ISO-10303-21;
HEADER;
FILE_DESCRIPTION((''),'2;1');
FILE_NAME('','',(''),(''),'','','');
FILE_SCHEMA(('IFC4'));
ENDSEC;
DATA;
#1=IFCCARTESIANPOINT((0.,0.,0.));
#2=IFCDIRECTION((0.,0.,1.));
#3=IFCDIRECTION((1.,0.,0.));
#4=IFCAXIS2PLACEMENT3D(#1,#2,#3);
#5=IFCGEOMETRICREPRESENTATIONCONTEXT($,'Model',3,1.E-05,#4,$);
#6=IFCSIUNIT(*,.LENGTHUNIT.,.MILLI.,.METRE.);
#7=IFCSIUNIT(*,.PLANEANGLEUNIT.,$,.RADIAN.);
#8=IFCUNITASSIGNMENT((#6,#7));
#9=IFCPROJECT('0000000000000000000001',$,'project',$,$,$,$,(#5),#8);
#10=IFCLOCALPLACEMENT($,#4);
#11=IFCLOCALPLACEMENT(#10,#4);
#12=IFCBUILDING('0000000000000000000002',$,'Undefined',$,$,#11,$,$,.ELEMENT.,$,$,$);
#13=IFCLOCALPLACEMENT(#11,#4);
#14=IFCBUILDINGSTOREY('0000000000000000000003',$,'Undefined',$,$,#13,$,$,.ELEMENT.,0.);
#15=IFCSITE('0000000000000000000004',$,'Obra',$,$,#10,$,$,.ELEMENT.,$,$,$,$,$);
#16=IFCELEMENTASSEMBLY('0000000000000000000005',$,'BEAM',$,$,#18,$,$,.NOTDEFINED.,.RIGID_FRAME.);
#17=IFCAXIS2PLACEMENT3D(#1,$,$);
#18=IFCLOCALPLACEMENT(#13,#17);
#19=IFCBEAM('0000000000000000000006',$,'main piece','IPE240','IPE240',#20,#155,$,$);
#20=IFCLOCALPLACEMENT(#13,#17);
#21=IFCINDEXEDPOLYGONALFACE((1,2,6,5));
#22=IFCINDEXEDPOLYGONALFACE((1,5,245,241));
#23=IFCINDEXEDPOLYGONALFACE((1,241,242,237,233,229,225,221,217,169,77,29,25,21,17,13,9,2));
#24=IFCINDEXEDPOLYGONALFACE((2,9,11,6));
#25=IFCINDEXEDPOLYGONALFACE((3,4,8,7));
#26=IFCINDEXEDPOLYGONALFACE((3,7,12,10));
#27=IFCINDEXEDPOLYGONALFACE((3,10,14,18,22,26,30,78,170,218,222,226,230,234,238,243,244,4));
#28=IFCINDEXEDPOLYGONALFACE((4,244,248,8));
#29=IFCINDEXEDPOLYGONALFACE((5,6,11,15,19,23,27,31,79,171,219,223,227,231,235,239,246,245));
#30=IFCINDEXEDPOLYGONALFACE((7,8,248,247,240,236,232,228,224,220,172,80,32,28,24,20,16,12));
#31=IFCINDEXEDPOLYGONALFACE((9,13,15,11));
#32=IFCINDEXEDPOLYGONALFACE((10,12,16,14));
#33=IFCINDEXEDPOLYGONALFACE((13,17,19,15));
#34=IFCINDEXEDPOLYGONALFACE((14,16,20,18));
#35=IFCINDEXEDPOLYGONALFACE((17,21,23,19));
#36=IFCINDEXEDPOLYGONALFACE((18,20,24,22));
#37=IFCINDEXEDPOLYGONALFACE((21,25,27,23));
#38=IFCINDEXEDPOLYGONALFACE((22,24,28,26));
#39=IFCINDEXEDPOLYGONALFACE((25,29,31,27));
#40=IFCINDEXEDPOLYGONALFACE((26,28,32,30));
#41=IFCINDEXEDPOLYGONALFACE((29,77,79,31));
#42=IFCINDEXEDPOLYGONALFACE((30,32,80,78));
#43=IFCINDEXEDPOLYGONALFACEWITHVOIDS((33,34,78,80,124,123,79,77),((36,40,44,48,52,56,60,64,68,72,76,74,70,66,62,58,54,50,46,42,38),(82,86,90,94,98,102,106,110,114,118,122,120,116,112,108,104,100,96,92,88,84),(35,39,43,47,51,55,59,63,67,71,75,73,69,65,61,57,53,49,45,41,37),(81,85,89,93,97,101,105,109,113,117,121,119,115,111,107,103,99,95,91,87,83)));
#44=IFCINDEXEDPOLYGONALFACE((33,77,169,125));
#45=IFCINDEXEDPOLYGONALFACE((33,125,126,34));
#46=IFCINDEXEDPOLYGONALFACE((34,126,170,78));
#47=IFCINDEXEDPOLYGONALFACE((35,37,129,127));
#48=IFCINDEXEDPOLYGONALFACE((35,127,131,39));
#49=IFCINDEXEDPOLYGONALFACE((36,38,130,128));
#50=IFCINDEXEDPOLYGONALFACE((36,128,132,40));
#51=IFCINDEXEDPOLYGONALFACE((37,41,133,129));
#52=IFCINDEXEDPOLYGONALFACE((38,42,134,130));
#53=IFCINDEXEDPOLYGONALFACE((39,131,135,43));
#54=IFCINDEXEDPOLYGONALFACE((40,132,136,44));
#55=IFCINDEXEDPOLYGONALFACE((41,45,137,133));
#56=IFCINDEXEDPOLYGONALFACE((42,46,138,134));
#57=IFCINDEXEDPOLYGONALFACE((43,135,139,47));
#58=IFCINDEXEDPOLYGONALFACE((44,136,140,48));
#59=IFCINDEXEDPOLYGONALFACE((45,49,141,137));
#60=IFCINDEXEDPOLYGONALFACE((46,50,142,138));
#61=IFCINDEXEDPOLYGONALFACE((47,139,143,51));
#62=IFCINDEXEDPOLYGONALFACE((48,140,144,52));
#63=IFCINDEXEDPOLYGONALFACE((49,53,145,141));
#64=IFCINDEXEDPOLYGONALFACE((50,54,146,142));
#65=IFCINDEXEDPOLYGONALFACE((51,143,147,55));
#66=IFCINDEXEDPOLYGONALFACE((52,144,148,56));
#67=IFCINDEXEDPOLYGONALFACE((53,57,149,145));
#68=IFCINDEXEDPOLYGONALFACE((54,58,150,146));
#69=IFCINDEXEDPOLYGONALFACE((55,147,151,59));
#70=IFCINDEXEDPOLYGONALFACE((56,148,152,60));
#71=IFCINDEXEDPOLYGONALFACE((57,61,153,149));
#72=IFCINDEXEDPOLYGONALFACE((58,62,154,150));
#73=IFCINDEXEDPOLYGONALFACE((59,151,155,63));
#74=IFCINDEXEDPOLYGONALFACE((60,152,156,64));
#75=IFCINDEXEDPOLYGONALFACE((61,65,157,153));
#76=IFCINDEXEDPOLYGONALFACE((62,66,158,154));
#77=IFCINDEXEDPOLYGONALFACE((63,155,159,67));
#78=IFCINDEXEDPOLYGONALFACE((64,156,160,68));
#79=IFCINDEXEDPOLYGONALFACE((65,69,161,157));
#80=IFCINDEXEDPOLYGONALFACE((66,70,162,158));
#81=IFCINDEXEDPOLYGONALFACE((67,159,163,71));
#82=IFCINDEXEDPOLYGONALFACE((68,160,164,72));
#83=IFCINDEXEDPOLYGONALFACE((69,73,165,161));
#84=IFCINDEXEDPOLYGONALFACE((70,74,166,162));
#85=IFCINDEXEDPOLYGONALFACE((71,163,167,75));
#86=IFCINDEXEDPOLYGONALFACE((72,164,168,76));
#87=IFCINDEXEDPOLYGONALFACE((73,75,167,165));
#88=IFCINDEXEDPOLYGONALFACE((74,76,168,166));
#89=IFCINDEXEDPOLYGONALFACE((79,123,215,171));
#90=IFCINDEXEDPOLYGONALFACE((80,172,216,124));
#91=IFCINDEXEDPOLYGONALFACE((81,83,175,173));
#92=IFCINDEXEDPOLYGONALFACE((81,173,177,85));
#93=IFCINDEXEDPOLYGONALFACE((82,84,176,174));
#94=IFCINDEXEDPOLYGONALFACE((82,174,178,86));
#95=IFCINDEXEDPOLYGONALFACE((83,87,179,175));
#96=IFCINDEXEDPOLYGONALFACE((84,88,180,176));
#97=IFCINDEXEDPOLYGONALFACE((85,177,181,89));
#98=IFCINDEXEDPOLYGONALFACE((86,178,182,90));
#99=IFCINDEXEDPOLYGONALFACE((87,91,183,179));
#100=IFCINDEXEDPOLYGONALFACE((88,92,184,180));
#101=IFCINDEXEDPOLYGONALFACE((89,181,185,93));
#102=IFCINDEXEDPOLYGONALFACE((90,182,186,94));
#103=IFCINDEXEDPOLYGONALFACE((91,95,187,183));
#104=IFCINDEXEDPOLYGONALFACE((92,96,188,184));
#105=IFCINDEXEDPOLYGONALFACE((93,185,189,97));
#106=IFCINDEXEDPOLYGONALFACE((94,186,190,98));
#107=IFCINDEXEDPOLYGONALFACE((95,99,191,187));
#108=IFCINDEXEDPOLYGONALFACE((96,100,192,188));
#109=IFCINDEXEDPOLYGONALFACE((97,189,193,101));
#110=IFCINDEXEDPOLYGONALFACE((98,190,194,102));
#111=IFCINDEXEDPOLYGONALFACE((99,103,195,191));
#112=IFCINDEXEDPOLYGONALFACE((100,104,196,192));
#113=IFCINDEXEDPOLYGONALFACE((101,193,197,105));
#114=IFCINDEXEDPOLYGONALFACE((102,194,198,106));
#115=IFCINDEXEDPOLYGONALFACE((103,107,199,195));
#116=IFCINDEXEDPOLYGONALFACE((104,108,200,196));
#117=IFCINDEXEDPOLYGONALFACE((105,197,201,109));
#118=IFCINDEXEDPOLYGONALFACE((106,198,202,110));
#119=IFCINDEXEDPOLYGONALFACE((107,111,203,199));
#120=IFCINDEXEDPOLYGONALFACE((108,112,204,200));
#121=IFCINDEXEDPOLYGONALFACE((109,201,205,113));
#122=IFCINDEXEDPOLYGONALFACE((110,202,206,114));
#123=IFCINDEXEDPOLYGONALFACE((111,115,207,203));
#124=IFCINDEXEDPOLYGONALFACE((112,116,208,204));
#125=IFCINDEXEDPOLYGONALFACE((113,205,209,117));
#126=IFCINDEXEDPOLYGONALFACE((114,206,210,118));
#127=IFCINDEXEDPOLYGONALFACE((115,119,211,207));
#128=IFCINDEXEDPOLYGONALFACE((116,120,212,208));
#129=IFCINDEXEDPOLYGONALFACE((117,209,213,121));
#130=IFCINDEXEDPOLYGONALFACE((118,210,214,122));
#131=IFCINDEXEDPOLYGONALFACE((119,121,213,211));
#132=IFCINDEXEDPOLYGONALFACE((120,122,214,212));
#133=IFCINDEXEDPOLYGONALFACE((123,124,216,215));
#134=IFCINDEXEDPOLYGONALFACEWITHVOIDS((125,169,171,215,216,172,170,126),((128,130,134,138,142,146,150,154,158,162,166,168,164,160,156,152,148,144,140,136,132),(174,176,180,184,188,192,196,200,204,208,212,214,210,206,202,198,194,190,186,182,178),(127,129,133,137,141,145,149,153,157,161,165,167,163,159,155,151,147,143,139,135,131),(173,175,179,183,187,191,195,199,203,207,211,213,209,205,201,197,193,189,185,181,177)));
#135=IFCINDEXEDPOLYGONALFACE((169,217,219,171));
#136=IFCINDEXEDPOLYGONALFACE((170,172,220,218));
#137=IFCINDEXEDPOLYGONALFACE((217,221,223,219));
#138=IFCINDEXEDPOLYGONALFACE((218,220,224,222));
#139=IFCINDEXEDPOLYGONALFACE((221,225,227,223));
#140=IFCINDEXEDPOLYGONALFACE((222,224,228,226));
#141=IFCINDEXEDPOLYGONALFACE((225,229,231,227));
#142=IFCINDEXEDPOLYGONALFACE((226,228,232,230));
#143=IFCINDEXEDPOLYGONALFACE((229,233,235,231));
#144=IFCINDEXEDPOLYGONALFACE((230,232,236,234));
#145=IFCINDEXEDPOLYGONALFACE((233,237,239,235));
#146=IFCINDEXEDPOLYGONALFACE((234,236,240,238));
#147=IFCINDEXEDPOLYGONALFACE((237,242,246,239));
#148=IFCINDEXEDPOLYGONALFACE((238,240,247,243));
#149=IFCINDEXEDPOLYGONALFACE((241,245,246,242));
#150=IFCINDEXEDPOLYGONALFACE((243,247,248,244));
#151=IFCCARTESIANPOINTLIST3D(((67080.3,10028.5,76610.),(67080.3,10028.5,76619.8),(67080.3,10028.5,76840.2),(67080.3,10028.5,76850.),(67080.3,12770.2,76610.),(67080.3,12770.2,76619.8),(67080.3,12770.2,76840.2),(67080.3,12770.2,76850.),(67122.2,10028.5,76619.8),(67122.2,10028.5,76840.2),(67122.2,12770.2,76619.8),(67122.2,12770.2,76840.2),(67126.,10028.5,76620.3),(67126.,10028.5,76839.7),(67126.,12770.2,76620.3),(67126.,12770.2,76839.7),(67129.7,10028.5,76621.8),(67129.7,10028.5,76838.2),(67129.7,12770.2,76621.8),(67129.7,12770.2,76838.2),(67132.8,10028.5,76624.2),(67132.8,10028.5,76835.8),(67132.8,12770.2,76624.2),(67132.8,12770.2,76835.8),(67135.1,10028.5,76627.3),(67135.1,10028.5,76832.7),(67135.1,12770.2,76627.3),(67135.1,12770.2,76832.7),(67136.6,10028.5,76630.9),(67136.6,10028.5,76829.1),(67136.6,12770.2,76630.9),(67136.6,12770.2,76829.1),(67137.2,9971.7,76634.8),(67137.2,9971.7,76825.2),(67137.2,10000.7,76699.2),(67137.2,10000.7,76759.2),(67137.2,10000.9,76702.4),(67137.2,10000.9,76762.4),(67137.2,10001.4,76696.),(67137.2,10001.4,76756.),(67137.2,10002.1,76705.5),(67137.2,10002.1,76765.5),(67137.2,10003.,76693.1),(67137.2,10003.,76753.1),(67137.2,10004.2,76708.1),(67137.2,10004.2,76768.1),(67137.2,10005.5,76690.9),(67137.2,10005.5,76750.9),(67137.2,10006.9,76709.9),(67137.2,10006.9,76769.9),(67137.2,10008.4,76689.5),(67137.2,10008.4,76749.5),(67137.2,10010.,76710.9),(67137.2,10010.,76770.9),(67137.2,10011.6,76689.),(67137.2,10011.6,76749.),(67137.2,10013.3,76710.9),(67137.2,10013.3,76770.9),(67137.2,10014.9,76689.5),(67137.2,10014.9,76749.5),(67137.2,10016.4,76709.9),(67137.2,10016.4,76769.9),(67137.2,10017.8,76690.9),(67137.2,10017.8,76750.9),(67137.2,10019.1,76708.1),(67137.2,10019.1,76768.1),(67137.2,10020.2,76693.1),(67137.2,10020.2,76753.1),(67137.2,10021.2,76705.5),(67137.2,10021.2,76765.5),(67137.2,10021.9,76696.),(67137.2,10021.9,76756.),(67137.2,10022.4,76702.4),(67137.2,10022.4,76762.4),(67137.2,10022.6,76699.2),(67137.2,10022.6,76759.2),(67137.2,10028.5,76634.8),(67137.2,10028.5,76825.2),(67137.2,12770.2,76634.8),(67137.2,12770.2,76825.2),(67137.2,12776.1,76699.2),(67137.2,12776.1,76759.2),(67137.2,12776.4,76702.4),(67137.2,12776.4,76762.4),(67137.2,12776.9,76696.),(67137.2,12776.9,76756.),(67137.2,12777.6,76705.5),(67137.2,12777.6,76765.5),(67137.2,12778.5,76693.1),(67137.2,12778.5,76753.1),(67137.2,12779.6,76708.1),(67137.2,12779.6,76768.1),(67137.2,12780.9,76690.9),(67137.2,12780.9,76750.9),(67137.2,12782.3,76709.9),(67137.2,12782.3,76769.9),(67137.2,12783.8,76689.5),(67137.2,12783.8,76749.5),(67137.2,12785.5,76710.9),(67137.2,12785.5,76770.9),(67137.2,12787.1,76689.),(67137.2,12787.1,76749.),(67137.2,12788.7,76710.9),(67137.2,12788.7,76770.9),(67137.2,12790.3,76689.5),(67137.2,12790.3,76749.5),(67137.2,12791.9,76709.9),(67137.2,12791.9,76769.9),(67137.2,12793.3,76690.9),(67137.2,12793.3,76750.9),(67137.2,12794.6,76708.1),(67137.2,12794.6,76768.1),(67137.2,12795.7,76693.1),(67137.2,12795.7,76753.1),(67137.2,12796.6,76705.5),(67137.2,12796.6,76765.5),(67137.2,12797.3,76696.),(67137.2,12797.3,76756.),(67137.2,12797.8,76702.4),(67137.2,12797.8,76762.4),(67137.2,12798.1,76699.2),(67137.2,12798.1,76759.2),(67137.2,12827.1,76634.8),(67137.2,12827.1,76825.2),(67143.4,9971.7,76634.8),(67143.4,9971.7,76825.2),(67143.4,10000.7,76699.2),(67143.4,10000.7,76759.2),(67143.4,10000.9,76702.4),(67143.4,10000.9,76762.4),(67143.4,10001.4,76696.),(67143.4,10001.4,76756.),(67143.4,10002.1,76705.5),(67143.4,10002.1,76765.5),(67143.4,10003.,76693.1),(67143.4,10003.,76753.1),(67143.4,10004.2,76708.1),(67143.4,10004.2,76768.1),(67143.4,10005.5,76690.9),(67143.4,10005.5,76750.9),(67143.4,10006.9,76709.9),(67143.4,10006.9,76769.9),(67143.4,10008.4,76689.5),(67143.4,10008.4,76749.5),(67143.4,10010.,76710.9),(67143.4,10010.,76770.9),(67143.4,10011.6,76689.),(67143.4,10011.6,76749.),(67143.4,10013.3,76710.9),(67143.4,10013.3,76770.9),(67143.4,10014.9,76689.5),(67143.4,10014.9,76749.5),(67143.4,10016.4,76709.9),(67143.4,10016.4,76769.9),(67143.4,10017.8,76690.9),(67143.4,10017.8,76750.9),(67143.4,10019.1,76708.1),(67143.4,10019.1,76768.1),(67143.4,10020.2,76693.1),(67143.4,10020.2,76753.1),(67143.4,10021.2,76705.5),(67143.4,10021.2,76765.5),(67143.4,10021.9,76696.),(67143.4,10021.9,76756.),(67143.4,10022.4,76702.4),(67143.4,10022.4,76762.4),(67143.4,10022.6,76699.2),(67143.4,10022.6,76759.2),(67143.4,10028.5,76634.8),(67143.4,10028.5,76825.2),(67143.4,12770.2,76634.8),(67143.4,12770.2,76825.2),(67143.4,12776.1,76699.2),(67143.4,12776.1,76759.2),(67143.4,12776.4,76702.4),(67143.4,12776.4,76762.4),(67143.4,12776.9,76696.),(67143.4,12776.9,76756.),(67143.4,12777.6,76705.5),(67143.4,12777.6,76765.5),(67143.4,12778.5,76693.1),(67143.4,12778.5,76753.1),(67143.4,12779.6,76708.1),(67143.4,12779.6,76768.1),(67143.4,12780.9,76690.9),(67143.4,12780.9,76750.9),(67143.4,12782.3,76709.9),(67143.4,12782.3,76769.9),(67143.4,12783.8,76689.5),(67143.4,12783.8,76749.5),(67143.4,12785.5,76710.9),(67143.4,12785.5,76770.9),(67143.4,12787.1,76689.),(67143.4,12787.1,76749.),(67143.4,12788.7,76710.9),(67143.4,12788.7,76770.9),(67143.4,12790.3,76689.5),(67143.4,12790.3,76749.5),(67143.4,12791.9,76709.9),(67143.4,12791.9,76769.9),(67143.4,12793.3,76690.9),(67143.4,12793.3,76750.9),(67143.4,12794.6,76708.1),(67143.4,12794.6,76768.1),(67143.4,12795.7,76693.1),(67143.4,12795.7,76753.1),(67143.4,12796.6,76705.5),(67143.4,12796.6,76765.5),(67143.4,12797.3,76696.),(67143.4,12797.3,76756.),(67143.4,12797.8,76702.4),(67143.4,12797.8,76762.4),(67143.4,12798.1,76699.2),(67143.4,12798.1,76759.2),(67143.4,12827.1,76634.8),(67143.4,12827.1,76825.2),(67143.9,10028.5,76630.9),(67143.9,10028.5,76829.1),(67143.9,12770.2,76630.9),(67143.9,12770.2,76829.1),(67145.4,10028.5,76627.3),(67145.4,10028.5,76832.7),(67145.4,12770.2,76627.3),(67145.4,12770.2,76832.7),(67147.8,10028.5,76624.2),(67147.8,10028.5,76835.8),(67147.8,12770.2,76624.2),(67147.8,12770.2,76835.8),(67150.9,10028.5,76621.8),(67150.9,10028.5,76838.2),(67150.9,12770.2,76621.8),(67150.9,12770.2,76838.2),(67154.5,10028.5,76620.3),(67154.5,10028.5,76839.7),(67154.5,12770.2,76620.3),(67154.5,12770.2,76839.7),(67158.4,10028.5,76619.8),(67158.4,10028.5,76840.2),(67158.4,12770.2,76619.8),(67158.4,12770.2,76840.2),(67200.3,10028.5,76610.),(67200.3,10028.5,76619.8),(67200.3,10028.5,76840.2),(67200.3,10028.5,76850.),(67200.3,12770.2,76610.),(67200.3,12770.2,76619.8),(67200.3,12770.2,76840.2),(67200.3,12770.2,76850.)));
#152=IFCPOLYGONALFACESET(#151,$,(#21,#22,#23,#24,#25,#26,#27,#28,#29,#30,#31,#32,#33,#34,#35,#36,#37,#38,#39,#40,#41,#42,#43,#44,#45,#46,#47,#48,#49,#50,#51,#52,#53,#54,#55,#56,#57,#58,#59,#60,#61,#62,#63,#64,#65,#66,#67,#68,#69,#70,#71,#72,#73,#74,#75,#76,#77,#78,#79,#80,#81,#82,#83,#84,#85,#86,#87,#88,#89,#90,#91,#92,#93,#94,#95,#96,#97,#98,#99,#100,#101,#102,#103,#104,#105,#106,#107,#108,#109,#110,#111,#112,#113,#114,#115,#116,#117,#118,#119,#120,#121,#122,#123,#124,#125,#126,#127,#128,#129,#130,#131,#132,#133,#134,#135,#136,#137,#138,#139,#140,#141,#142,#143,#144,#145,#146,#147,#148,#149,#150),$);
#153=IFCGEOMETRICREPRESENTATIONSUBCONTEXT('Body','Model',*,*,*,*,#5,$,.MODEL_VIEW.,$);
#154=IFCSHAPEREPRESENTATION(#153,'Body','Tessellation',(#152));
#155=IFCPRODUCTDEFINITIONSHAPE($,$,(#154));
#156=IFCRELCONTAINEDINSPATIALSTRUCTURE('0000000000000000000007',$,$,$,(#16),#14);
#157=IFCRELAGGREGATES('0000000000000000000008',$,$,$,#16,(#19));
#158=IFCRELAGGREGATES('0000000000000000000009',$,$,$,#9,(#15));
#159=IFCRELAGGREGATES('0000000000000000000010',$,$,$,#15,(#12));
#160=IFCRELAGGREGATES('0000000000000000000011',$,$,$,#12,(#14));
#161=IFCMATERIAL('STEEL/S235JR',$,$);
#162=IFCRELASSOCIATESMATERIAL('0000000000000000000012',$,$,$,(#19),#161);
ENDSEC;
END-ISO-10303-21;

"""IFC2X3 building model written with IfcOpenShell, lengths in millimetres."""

from ifc_helpers import new_model, si_unit, frame, origin_with_axes, origin_2d_with_axis, place, context, subcontext, project, spatial, rectangle, circle, i_section, extrude, clip, halfspace, source, transform, mapped, material, element, aggregate, save


model = new_model("IFC2X3")

# Units and contexts
model_context = context("Model", 3, precision=1e-05, world=origin_with_axes())
body_context = subcontext(model_context, "Body", "Model", "MODEL_VIEW")
ifc_project = project(units=[si_unit("LENGTHUNIT", "METRE", prefix="MILLI"), si_unit("PLANEANGLEUNIT", "RADIAN")], contexts=[model_context])

# Site, building, storey
site_placement = place(None, origin_with_axes())
site = spatial("IfcSite", under=ifc_project, at=site_placement, Name="Obra", CompositionType="ELEMENT")
building_placement = place(site_placement, origin_with_axes())
building = spatial("IfcBuilding", under=site, at=building_placement, Name="Undefined", CompositionType="ELEMENT")
storey_placement = place(building_placement, origin_with_axes())
storey = spatial("IfcBuildingStorey", under=building, at=storey_placement, Name="Undefined", CompositionType="ELEMENT", Elevation=0.0)

# Element assembly, beam, openings
ifc_material_1 = material(Name="STEEL/S235JR")
shared_shape_1 = source(origin_with_axes(), body_context, "Body", "SweptSolid", [
    extrude(circle(Radius=11.0, at=origin_2d_with_axis()), frame((0.0, -3.2, 0.0), z_axis=(0.0, 1.0, 0.0), x_axis=(1.0, 0.0, 0.0)), (0.0, 0.0, 1.0), 6.4),
])
assembly_1_placement = place(storey_placement, origin_with_axes())
assembly_1 = element("IfcElementAssembly", 1, at=assembly_1_placement, inside=storey, Name="BEAM", AssemblyPlace="NOTDEFINED", PredefinedType="RIGID_FRAME")
beam_1_placement = place(assembly_1_placement, frame((67140.3, 10031.2, 76730.0), z_axis=(0.0, 0.0, 1.0), x_axis=(0.0, 1.0, 0.0)))
beam_1 = element("IfcBeam", 2, at=beam_1_placement, material=ifc_material_1, Name="main piece", Description="IPE240", ObjectType="IPE240", context=body_context, shape_type="Clipping", body=[
    clip(clip(extrude(i_section(OverallWidth=120.0, OverallDepth=240.0, WebThickness=6.2, FlangeThickness=9.8, FilletRadius=15.0, at=origin_2d_with_axis()), frame((2795.9, 0.0, 0.0), z_axis=(-1.0, 0.0, 0.0), x_axis=(0.0, -1.0, 0.0)), (0.0, 0.0, 1.0), 2855.4), halfspace(frame((2795.9, 0.0, -220.0), z_axis=(-1.0, 0.0, 0.0), x_axis=(0.0, 1.0, 0.0)), True)), halfspace(frame((-59.5, 0.0, -220.0), z_axis=(1.0, 0.0, 0.0), x_axis=(0.0, -1.0, 0.0)), True)),
])
opening_1_placement = place(assembly_1_placement, frame((67140.3, 10031.2, 76730.0), z_axis=(0.0, 0.0, 1.0), x_axis=(0.0, 1.0, 0.0)))
element("IfcOpeningElement", 3, at=opening_1_placement, cuts=beam_1, ObjectType="Recess", context=body_context, shape_type="SweptSolid", body=[
    extrude(rectangle(XDim=25.8, YDim=68.9, at=origin_2d_with_axis()), frame((-37.1, -61.0, -108.1), z_axis=(0.0, 1.0, 0.0), x_axis=(0.0, 0.0, -1.0)), (0.0, 0.0, 1.0), 122.0),
])
opening_2_placement = place(assembly_1_placement, frame((67140.3, 10031.2, 76730.0), z_axis=(0.0, 0.0, 1.0), x_axis=(0.0, 1.0, 0.0)))
element("IfcOpeningElement", 4, at=opening_2_placement, cuts=beam_1, ObjectType="Recess", context=body_context, shape_type="SweptSolid", body=[
    extrude(rectangle(XDim=25.8, YDim=68.9, at=origin_2d_with_axis()), frame((-37.1, -61.0, 108.1), z_axis=(0.0, 1.0, 0.0), x_axis=(0.0, 0.0, -1.0)), (0.0, 0.0, 1.0), 122.0),
])
opening_3_placement = place(assembly_1_placement, frame((67140.3, 10031.2, 76730.0), z_axis=(0.0, 0.0, 1.0), x_axis=(0.0, 1.0, 0.0)))
element("IfcOpeningElement", 5, at=opening_3_placement, cuts=beam_1, ObjectType="Recess", context=body_context, shape_type="SweptSolid", body=[
    extrude(rectangle(XDim=25.8, YDim=68.9, at=origin_2d_with_axis()), frame((2773.5, 61.0, -108.1), z_axis=(0.0, -1.0, 0.0), x_axis=(0.0, 0.0, -1.0)), (0.0, 0.0, 1.0), 122.0),
])
opening_4_placement = place(assembly_1_placement, frame((67140.3, 10031.2, 76730.0), z_axis=(0.0, 0.0, 1.0), x_axis=(0.0, 1.0, 0.0)))
element("IfcOpeningElement", 6, at=opening_4_placement, cuts=beam_1, ObjectType="Recess", context=body_context, shape_type="SweptSolid", body=[
    extrude(rectangle(XDim=25.8, YDim=68.9, at=origin_2d_with_axis()), frame((2773.5, 61.0, 108.1), z_axis=(0.0, -1.0, 0.0), x_axis=(0.0, 0.0, -1.0)), (0.0, 0.0, 1.0), 122.0),
])
opening_5_placement = place(assembly_1_placement, frame((67140.3, 9971.6, 76850.0), z_axis=(0.0, 1.0, 0.0), x_axis=(0.0, 0.0, -1.0)))
element("IfcOpeningElement", 7, at=opening_5_placement, cuts=beam_1, ObjectType="Opening", context=body_context, shape_type="MappedRepresentation", body=[
    mapped(shared_shape_1, transform((90.0, 0.0, 40.0))),
    mapped(shared_shape_1, transform((150.0, 0.0, 40.0))),
])
opening_6_placement = place(assembly_1_placement, frame((67140.3, 12827.1, 76850.0), z_axis=(0.0, -1.0, 0.0), x_axis=(0.0, 0.0, -1.0)))
element("IfcOpeningElement", 8, at=opening_6_placement, cuts=beam_1, ObjectType="Opening", context=body_context, shape_type="MappedRepresentation", body=[
    mapped(shared_shape_1, transform((90.0, 0.0, 40.0))),
    mapped(shared_shape_1, transform((150.0, 0.0, 40.0))),
])

aggregate(assembly_1, [beam_1])

save(model, "model.ifc")
